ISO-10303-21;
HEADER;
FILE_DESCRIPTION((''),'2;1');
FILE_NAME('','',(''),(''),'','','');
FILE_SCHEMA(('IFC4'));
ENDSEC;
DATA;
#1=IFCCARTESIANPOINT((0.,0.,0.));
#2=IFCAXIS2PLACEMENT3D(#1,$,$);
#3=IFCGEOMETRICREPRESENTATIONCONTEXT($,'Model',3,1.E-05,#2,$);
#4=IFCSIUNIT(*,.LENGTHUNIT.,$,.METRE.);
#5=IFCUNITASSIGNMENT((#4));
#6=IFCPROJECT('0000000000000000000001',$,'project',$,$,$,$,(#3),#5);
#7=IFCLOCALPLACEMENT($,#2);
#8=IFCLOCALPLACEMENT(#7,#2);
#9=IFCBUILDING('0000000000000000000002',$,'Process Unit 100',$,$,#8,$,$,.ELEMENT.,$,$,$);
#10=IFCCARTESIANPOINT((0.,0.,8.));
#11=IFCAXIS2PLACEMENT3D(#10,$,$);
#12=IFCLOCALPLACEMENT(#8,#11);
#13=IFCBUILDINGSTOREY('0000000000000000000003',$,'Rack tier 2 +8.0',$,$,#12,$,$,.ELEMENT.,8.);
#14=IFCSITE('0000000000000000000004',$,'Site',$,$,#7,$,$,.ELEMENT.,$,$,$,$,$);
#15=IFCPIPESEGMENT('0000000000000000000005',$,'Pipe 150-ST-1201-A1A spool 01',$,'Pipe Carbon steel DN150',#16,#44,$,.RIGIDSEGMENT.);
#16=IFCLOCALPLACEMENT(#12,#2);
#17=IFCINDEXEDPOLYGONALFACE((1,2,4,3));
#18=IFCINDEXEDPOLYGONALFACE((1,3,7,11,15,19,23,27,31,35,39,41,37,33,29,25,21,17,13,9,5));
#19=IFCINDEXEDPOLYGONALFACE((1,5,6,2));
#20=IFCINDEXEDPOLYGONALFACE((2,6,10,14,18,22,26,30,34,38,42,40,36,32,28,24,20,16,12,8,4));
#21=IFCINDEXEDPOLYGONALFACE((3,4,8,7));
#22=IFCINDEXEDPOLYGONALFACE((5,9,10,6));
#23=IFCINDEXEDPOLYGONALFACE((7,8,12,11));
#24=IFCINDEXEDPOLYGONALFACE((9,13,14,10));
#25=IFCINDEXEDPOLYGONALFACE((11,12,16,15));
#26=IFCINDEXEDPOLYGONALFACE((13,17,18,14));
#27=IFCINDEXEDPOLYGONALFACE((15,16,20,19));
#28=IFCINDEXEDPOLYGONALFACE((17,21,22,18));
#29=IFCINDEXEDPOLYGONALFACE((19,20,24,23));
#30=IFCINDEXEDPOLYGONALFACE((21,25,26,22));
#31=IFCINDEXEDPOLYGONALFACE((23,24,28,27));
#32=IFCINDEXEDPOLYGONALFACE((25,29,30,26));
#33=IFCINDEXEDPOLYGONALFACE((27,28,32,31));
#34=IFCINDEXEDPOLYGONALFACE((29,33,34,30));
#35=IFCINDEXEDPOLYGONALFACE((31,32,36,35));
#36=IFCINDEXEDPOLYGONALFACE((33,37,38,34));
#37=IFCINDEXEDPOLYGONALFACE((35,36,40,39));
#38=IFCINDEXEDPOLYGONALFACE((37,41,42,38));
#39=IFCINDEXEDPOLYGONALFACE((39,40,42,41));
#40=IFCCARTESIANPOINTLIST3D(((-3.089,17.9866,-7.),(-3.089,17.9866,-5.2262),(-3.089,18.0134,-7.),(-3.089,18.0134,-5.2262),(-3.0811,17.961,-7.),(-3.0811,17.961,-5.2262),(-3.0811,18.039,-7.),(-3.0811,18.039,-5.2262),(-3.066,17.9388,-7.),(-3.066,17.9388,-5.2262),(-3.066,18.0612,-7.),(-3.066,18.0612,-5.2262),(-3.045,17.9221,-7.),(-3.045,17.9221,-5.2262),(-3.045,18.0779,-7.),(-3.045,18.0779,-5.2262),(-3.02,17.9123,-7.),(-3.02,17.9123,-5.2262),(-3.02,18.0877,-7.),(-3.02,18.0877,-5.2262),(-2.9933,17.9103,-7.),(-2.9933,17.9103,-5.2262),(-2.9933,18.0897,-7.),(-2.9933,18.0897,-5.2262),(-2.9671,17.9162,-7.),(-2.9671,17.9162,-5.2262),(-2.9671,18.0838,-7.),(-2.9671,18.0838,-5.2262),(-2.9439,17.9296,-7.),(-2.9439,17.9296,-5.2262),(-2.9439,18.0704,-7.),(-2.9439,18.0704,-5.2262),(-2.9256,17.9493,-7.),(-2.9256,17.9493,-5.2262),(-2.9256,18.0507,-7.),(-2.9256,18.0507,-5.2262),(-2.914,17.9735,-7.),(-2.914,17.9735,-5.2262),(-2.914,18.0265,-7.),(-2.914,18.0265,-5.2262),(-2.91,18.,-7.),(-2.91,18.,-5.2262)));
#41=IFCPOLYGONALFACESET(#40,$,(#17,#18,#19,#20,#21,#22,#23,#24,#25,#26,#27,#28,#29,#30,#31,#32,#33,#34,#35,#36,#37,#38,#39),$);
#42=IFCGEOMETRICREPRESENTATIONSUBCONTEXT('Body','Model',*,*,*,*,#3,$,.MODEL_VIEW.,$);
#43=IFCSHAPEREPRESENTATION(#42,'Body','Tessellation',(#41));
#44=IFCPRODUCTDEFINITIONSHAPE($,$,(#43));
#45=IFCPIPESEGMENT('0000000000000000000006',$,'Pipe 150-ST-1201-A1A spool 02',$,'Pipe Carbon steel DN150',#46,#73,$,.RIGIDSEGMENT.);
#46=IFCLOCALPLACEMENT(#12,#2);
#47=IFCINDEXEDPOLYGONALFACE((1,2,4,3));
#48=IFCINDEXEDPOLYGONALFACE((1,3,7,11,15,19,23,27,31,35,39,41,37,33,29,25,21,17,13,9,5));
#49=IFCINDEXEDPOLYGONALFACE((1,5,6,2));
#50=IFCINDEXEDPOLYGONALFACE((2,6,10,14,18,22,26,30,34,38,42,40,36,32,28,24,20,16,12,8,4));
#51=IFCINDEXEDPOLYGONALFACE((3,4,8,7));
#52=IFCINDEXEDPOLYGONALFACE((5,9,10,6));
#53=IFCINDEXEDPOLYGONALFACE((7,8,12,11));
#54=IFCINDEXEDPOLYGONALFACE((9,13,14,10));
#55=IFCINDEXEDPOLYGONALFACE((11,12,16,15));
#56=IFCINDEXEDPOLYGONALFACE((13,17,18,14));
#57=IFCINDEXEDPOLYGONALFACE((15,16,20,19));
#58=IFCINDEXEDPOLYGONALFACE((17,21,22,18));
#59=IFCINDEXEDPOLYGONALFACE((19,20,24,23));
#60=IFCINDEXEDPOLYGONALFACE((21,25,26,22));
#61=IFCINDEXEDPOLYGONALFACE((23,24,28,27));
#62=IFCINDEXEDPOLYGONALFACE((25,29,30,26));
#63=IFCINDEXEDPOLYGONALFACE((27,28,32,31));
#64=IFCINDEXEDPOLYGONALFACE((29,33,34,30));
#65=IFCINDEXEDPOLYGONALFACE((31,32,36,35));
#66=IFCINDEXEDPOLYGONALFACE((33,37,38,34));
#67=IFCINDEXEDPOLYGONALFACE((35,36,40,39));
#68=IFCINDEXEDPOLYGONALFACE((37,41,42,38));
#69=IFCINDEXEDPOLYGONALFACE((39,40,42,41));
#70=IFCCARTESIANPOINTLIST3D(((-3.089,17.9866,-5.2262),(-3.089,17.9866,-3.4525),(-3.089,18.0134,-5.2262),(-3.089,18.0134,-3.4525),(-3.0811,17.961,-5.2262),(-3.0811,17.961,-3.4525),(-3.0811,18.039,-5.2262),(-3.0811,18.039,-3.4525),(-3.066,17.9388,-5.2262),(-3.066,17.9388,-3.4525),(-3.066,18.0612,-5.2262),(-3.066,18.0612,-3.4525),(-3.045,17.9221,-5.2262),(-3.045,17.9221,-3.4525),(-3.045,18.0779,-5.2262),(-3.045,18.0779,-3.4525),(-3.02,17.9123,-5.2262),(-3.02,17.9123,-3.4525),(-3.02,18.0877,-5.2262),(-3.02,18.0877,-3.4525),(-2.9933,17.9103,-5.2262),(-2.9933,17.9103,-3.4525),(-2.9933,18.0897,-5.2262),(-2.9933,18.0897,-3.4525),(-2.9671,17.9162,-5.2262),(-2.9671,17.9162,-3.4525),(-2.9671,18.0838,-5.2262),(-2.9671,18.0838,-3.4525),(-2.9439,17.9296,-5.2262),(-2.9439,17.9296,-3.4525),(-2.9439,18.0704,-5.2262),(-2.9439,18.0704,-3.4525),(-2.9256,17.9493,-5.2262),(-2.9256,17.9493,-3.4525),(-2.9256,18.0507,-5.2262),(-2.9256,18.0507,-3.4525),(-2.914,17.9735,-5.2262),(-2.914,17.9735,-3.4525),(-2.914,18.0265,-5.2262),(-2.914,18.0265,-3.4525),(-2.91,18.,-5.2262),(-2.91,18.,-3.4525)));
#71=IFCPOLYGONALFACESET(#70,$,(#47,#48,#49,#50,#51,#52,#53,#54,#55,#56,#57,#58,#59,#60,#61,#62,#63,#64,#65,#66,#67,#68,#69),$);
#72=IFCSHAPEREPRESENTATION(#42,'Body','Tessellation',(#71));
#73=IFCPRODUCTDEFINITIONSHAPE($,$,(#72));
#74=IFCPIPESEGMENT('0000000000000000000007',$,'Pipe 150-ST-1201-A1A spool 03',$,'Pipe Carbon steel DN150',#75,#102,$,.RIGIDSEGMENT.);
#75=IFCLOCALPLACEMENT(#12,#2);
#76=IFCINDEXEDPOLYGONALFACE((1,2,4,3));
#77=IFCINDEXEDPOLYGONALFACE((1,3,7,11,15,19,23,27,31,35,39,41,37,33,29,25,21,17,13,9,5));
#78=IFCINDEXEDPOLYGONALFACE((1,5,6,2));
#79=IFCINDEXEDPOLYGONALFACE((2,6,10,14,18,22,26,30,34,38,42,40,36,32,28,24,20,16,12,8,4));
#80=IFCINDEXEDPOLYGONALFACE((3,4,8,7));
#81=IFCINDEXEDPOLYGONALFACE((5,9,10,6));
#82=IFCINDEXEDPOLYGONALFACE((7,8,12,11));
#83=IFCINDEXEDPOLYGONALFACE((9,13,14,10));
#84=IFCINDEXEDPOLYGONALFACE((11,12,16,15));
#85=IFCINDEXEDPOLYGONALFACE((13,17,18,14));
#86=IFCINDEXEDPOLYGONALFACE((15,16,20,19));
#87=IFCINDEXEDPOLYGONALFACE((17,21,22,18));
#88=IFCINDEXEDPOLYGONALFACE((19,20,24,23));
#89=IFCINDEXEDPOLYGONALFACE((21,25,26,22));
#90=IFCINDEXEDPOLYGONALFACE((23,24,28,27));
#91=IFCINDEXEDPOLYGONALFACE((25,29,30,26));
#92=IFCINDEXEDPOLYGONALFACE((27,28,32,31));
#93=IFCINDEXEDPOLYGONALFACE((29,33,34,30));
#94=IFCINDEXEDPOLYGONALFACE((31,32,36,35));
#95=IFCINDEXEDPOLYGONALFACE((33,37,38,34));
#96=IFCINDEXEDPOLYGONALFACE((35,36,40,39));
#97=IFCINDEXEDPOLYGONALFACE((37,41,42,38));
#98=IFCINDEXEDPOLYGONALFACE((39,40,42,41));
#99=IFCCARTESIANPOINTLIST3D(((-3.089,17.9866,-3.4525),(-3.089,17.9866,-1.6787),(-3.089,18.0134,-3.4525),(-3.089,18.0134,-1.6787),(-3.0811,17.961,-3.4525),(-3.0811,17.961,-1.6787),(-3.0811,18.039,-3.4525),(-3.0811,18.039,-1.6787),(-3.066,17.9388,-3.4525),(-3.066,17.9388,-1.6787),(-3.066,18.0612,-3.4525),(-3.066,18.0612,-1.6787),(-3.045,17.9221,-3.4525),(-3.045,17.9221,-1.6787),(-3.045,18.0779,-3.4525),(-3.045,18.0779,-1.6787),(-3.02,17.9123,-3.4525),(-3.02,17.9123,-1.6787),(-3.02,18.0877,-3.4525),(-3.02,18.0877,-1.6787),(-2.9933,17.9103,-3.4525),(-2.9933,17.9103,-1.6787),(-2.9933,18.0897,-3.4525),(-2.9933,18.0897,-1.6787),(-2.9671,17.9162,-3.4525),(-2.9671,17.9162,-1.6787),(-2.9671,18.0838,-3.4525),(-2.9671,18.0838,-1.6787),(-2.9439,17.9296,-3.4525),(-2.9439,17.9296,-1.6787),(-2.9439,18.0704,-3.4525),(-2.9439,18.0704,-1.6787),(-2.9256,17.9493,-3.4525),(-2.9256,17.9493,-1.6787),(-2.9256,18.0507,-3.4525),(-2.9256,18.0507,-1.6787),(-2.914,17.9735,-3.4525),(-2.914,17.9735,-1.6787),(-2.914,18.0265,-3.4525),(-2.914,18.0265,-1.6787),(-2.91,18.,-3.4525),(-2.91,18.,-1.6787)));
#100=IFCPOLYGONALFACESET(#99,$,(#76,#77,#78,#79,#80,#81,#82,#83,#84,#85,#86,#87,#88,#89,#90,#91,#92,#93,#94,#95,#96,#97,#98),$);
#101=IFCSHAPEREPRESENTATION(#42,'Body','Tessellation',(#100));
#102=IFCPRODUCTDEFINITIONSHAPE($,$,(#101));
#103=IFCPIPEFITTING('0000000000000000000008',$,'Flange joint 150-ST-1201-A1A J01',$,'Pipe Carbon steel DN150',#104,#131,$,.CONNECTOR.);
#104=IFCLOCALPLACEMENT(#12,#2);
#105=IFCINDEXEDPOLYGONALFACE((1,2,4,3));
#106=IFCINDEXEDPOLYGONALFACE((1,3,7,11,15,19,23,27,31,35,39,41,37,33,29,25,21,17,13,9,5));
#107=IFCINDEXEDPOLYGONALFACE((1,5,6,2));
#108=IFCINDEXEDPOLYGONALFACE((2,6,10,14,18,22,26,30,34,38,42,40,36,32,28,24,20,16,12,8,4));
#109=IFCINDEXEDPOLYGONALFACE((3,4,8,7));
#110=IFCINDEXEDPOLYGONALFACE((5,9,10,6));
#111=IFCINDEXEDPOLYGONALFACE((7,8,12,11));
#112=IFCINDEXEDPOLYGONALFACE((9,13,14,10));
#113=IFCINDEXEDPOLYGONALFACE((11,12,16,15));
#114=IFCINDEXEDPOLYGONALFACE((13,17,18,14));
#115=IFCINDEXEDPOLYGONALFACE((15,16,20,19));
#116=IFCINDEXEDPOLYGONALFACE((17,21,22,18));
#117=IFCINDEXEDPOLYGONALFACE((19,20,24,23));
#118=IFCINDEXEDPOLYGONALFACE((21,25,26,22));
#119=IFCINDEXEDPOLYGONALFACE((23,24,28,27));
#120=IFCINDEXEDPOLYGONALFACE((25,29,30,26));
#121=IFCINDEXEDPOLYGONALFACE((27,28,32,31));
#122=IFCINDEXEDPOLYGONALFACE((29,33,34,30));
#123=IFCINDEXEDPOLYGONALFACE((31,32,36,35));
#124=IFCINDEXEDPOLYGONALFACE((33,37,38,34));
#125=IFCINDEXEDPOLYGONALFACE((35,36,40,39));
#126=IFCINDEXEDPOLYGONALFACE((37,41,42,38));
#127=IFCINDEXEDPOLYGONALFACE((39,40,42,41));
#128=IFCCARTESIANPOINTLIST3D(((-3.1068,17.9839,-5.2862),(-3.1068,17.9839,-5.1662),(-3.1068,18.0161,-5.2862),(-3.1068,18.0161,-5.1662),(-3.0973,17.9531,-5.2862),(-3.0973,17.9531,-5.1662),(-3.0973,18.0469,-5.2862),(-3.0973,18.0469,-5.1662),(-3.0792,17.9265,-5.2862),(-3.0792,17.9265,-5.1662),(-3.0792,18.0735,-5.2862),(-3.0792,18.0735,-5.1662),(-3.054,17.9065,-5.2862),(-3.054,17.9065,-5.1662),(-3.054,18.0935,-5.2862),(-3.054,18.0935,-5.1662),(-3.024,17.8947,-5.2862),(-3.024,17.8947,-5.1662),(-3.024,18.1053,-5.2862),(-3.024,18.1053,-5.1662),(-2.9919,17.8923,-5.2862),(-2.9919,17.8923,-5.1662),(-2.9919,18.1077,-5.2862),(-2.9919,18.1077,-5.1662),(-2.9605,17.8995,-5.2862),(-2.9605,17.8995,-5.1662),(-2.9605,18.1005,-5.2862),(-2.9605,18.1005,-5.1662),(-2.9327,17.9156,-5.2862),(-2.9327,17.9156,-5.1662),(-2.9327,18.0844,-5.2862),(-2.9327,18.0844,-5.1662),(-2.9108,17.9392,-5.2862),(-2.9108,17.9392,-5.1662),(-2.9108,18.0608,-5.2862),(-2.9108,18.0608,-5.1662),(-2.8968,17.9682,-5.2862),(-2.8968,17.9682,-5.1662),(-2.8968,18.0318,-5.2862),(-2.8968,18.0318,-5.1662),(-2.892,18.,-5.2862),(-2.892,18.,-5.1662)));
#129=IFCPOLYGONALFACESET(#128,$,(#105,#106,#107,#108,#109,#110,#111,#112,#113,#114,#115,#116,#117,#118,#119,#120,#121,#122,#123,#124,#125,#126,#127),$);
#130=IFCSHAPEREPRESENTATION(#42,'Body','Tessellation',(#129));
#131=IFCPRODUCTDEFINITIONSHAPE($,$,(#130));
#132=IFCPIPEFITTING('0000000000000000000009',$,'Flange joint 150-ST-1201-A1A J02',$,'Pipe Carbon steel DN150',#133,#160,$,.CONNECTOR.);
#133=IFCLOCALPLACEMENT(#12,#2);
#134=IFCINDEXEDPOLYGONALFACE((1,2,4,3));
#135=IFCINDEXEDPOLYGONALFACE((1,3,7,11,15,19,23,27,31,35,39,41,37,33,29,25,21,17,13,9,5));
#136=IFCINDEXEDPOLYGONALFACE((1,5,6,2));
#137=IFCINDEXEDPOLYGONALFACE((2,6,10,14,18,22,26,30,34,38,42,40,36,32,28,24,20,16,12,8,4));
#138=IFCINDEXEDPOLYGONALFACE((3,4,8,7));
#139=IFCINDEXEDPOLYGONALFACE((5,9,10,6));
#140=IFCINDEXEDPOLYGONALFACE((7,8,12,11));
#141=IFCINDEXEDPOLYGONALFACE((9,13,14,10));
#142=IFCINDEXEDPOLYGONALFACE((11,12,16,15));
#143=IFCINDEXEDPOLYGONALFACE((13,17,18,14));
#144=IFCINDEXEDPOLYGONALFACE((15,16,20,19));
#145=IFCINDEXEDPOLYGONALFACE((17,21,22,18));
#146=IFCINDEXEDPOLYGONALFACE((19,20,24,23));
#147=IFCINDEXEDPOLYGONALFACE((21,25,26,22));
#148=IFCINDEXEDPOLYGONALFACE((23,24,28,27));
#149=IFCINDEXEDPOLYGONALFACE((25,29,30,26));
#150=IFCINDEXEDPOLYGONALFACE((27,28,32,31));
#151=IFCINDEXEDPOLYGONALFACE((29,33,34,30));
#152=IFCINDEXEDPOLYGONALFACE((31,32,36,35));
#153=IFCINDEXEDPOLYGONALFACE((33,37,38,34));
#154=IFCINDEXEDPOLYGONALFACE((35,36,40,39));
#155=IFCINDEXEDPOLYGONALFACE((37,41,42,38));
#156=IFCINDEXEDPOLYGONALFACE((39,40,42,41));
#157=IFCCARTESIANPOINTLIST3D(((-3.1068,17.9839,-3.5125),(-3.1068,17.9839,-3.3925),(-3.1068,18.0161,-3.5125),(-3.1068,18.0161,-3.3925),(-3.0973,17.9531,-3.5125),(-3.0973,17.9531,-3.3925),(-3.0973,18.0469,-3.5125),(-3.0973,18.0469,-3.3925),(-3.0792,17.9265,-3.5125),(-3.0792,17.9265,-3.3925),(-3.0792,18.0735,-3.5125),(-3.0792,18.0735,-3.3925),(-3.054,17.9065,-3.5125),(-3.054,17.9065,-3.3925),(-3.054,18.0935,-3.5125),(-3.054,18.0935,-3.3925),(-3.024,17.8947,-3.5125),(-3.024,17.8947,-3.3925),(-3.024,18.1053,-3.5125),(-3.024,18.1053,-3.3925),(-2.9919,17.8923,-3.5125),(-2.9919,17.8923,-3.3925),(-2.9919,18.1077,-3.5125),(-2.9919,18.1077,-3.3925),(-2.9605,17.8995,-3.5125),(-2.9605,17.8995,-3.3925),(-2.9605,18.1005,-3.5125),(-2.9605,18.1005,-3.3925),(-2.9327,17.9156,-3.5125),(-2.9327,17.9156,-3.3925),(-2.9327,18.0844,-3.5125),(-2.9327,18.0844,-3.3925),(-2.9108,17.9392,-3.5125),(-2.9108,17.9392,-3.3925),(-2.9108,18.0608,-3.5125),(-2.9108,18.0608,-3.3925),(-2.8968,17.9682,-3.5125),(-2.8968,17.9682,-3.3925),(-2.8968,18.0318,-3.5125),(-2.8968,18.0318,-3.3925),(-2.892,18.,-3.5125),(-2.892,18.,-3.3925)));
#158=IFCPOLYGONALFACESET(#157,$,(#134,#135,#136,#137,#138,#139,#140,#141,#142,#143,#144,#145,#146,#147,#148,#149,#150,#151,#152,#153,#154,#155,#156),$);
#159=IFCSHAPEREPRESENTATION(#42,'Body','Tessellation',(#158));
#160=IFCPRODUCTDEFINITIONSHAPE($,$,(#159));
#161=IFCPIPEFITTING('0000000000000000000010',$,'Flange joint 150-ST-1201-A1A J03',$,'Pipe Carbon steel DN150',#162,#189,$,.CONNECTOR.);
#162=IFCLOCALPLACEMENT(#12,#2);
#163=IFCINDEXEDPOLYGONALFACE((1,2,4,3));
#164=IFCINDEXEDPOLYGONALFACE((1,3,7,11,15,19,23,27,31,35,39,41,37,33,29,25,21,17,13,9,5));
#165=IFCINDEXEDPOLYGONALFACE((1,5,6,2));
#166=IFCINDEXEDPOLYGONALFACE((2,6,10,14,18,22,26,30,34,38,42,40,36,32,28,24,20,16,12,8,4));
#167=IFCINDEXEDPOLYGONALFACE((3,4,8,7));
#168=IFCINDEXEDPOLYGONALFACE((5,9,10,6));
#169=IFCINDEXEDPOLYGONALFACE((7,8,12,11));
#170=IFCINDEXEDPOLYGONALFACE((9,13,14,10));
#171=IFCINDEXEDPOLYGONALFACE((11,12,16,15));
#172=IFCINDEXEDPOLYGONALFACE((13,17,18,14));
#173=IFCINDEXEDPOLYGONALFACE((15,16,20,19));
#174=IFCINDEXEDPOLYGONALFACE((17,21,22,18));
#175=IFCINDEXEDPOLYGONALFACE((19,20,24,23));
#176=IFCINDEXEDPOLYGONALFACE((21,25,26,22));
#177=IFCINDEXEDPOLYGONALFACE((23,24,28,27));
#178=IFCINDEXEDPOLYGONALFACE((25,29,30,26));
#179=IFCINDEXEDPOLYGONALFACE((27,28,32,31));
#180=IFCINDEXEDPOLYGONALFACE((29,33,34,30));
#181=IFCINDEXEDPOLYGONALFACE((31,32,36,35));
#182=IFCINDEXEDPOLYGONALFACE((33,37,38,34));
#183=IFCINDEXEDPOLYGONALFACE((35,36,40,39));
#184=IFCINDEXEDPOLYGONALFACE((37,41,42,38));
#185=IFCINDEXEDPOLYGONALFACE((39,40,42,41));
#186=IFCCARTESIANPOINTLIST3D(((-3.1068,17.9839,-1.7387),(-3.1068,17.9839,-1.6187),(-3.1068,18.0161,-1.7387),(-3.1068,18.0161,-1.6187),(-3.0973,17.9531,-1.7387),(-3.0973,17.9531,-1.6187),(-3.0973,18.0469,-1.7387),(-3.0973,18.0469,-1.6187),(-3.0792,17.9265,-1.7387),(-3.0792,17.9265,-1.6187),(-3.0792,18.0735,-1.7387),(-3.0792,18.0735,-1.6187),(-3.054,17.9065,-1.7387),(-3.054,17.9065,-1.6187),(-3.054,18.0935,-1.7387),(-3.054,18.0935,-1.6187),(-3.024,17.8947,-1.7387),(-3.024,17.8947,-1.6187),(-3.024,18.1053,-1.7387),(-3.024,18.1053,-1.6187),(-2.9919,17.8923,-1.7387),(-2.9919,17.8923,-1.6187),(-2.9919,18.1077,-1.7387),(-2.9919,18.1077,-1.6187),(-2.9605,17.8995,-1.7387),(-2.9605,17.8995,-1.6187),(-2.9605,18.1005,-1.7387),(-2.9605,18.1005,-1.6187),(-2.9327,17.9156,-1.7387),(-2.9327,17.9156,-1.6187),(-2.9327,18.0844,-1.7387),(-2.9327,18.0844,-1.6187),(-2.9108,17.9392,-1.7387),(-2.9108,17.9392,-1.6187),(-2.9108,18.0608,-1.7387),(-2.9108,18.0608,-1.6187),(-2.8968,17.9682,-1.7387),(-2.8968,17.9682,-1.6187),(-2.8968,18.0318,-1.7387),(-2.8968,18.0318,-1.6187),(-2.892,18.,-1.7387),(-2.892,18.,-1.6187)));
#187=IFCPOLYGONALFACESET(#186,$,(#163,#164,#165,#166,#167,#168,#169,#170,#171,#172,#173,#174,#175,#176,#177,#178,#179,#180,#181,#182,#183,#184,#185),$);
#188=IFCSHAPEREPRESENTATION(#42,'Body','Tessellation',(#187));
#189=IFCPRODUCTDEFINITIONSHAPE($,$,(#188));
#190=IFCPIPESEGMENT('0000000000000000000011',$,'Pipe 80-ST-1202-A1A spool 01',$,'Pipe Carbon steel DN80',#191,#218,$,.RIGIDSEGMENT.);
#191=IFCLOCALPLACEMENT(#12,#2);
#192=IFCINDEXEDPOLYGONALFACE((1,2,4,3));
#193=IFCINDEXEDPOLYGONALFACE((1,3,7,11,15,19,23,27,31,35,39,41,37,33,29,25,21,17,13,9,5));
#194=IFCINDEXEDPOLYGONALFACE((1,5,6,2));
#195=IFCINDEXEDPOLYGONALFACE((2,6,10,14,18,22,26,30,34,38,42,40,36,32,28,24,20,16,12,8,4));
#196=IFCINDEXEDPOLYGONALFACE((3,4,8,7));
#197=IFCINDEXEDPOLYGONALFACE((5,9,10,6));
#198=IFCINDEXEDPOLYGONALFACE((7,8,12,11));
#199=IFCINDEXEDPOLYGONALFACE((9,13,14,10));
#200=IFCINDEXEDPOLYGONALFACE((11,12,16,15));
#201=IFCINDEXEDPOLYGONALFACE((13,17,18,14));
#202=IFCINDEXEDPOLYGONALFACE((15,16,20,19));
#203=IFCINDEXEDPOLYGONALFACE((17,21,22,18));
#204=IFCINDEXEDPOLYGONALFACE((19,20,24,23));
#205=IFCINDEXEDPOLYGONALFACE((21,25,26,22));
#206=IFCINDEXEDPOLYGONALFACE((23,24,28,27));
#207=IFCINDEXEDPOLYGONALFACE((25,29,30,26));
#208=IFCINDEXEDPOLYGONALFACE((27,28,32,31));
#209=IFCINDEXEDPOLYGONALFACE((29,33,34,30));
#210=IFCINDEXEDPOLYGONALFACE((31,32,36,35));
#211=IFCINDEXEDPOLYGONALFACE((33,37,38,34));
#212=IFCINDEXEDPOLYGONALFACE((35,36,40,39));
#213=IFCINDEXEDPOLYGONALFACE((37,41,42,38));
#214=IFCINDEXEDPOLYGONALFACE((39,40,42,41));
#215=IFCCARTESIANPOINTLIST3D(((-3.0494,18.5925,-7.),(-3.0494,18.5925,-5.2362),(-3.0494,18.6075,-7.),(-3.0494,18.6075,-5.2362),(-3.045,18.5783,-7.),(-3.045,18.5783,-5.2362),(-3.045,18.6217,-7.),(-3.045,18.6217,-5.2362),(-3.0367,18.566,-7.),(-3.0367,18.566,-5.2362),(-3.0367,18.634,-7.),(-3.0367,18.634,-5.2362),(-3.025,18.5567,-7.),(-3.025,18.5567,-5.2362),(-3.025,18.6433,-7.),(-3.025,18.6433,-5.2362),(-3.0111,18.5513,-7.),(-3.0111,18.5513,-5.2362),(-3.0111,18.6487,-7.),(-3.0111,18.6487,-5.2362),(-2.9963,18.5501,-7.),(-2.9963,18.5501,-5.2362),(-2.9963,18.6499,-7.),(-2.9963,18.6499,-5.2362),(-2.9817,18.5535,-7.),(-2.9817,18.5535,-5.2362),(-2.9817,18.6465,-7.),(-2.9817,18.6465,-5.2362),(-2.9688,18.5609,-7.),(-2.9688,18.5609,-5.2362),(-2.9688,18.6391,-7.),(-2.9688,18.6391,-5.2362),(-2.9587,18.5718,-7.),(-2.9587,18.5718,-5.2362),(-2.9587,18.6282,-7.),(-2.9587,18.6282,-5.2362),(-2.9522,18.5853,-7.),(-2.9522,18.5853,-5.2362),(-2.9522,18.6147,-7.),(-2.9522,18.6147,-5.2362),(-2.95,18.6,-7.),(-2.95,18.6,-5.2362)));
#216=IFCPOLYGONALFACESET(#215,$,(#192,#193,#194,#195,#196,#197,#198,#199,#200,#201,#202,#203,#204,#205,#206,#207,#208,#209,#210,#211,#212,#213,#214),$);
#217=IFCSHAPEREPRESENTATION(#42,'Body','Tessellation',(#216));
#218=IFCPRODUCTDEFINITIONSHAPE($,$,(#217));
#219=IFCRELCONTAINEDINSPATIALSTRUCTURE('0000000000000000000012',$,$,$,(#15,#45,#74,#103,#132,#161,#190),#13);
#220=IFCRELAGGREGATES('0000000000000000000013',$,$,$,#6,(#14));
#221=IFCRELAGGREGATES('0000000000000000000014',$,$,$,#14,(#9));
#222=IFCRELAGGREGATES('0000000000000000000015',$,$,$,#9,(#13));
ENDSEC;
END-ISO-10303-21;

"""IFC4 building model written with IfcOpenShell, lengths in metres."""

from ifc_helpers import new_model, si_unit, frame, origin, place, context, subcontext, project, spatial, circle, extrude, element, save


model = new_model("IFC4")

# Units and contexts
model_context = context("Model", 3, precision=1e-05, world=origin())
body_context = subcontext(model_context, "Body", "Model", "MODEL_VIEW")
ifc_project = project(units=[si_unit("LENGTHUNIT", "METRE")], contexts=[model_context])

# Site, building, storey
site_placement = place(None, origin())
site = spatial("IfcSite", under=ifc_project, at=site_placement, Name="Site", CompositionType="ELEMENT")
building_placement = place(site_placement, origin())
building = spatial("IfcBuilding", under=site, at=building_placement, Name="Process Unit 100", CompositionType="ELEMENT")
storey_placement = place(building_placement, frame((0.0, 0.0, 8.0)))
storey = spatial("IfcBuildingStorey", under=building, at=storey_placement, Name="Rack tier 2 +8.0", CompositionType="ELEMENT", Elevation=8.0)

# Pipe segments
for number, where, z_axis, x_axis, name in (
    (1, (-3.0, 18.0, -7.0), (0.0, 0.0, 1.0), (1.0, 0.0, 0.0), "Pipe 150-ST-1201-A1A spool 01"),
    (2, (-3.0, 18.0, -5.2263), (0.0, 0.0, 1.0), (1.0, 0.0, 0.0), "Pipe 150-ST-1201-A1A spool 02"),
    (3, (-3.0, 18.0, -3.4525), (0.0, 0.0, 1.0), (1.0, 0.0, 0.0), "Pipe 150-ST-1201-A1A spool 03"),
):
    element("IfcPipeSegment", number, at=place(storey_placement, frame(where, z_axis=z_axis, x_axis=x_axis)), inside=storey, Name=name, ObjectType="Pipe Carbon steel DN150", PredefinedType="RIGIDSEGMENT", context=body_context, shape_type="SweptSolid", body=[
        extrude(circle(Radius=0.09), origin(), (0.0, 0.0, 1.0), 1.7738),
    ])

# Pipe fittings
for number, where, z_axis, x_axis, name in (
    (4, (-3.0, 18.0, -5.2862), (0.0, 0.0, 1.0), (1.0, 0.0, 0.0), "Flange joint 150-ST-1201-A1A J01"),
    (5, (-3.0, 18.0, -3.5125), (0.0, 0.0, 1.0), (1.0, 0.0, 0.0), "Flange joint 150-ST-1201-A1A J02"),
    (6, (-3.0, 18.0, -1.7387), (0.0, 0.0, 1.0), (1.0, 0.0, 0.0), "Flange joint 150-ST-1201-A1A J03"),
):
    element("IfcPipeFitting", number, at=place(storey_placement, frame(where, z_axis=z_axis, x_axis=x_axis)), inside=storey, Name=name, ObjectType="Pipe Carbon steel DN150", PredefinedType="CONNECTOR", context=body_context, shape_type="SweptSolid", body=[
        extrude(circle(Radius=0.108), origin(), (0.0, 0.0, 1.0), 0.12),
    ])

# Pipe segment
for number, where, z_axis, x_axis, name in (
    (7, (-3.0, 18.6, -7.0), (0.0, 0.0, 1.0), (1.0, 0.0, 0.0), "Pipe 80-ST-1202-A1A spool 01"),
):
    element("IfcPipeSegment", number, at=place(storey_placement, frame(where, z_axis=z_axis, x_axis=x_axis)), inside=storey, Name=name, ObjectType="Pipe Carbon steel DN80", PredefinedType="RIGIDSEGMENT", context=body_context, shape_type="SweptSolid", body=[
        extrude(circle(Radius=0.05), origin(), (0.0, 0.0, 1.0), 1.7638),
    ])

save(model, "model.ifc")
